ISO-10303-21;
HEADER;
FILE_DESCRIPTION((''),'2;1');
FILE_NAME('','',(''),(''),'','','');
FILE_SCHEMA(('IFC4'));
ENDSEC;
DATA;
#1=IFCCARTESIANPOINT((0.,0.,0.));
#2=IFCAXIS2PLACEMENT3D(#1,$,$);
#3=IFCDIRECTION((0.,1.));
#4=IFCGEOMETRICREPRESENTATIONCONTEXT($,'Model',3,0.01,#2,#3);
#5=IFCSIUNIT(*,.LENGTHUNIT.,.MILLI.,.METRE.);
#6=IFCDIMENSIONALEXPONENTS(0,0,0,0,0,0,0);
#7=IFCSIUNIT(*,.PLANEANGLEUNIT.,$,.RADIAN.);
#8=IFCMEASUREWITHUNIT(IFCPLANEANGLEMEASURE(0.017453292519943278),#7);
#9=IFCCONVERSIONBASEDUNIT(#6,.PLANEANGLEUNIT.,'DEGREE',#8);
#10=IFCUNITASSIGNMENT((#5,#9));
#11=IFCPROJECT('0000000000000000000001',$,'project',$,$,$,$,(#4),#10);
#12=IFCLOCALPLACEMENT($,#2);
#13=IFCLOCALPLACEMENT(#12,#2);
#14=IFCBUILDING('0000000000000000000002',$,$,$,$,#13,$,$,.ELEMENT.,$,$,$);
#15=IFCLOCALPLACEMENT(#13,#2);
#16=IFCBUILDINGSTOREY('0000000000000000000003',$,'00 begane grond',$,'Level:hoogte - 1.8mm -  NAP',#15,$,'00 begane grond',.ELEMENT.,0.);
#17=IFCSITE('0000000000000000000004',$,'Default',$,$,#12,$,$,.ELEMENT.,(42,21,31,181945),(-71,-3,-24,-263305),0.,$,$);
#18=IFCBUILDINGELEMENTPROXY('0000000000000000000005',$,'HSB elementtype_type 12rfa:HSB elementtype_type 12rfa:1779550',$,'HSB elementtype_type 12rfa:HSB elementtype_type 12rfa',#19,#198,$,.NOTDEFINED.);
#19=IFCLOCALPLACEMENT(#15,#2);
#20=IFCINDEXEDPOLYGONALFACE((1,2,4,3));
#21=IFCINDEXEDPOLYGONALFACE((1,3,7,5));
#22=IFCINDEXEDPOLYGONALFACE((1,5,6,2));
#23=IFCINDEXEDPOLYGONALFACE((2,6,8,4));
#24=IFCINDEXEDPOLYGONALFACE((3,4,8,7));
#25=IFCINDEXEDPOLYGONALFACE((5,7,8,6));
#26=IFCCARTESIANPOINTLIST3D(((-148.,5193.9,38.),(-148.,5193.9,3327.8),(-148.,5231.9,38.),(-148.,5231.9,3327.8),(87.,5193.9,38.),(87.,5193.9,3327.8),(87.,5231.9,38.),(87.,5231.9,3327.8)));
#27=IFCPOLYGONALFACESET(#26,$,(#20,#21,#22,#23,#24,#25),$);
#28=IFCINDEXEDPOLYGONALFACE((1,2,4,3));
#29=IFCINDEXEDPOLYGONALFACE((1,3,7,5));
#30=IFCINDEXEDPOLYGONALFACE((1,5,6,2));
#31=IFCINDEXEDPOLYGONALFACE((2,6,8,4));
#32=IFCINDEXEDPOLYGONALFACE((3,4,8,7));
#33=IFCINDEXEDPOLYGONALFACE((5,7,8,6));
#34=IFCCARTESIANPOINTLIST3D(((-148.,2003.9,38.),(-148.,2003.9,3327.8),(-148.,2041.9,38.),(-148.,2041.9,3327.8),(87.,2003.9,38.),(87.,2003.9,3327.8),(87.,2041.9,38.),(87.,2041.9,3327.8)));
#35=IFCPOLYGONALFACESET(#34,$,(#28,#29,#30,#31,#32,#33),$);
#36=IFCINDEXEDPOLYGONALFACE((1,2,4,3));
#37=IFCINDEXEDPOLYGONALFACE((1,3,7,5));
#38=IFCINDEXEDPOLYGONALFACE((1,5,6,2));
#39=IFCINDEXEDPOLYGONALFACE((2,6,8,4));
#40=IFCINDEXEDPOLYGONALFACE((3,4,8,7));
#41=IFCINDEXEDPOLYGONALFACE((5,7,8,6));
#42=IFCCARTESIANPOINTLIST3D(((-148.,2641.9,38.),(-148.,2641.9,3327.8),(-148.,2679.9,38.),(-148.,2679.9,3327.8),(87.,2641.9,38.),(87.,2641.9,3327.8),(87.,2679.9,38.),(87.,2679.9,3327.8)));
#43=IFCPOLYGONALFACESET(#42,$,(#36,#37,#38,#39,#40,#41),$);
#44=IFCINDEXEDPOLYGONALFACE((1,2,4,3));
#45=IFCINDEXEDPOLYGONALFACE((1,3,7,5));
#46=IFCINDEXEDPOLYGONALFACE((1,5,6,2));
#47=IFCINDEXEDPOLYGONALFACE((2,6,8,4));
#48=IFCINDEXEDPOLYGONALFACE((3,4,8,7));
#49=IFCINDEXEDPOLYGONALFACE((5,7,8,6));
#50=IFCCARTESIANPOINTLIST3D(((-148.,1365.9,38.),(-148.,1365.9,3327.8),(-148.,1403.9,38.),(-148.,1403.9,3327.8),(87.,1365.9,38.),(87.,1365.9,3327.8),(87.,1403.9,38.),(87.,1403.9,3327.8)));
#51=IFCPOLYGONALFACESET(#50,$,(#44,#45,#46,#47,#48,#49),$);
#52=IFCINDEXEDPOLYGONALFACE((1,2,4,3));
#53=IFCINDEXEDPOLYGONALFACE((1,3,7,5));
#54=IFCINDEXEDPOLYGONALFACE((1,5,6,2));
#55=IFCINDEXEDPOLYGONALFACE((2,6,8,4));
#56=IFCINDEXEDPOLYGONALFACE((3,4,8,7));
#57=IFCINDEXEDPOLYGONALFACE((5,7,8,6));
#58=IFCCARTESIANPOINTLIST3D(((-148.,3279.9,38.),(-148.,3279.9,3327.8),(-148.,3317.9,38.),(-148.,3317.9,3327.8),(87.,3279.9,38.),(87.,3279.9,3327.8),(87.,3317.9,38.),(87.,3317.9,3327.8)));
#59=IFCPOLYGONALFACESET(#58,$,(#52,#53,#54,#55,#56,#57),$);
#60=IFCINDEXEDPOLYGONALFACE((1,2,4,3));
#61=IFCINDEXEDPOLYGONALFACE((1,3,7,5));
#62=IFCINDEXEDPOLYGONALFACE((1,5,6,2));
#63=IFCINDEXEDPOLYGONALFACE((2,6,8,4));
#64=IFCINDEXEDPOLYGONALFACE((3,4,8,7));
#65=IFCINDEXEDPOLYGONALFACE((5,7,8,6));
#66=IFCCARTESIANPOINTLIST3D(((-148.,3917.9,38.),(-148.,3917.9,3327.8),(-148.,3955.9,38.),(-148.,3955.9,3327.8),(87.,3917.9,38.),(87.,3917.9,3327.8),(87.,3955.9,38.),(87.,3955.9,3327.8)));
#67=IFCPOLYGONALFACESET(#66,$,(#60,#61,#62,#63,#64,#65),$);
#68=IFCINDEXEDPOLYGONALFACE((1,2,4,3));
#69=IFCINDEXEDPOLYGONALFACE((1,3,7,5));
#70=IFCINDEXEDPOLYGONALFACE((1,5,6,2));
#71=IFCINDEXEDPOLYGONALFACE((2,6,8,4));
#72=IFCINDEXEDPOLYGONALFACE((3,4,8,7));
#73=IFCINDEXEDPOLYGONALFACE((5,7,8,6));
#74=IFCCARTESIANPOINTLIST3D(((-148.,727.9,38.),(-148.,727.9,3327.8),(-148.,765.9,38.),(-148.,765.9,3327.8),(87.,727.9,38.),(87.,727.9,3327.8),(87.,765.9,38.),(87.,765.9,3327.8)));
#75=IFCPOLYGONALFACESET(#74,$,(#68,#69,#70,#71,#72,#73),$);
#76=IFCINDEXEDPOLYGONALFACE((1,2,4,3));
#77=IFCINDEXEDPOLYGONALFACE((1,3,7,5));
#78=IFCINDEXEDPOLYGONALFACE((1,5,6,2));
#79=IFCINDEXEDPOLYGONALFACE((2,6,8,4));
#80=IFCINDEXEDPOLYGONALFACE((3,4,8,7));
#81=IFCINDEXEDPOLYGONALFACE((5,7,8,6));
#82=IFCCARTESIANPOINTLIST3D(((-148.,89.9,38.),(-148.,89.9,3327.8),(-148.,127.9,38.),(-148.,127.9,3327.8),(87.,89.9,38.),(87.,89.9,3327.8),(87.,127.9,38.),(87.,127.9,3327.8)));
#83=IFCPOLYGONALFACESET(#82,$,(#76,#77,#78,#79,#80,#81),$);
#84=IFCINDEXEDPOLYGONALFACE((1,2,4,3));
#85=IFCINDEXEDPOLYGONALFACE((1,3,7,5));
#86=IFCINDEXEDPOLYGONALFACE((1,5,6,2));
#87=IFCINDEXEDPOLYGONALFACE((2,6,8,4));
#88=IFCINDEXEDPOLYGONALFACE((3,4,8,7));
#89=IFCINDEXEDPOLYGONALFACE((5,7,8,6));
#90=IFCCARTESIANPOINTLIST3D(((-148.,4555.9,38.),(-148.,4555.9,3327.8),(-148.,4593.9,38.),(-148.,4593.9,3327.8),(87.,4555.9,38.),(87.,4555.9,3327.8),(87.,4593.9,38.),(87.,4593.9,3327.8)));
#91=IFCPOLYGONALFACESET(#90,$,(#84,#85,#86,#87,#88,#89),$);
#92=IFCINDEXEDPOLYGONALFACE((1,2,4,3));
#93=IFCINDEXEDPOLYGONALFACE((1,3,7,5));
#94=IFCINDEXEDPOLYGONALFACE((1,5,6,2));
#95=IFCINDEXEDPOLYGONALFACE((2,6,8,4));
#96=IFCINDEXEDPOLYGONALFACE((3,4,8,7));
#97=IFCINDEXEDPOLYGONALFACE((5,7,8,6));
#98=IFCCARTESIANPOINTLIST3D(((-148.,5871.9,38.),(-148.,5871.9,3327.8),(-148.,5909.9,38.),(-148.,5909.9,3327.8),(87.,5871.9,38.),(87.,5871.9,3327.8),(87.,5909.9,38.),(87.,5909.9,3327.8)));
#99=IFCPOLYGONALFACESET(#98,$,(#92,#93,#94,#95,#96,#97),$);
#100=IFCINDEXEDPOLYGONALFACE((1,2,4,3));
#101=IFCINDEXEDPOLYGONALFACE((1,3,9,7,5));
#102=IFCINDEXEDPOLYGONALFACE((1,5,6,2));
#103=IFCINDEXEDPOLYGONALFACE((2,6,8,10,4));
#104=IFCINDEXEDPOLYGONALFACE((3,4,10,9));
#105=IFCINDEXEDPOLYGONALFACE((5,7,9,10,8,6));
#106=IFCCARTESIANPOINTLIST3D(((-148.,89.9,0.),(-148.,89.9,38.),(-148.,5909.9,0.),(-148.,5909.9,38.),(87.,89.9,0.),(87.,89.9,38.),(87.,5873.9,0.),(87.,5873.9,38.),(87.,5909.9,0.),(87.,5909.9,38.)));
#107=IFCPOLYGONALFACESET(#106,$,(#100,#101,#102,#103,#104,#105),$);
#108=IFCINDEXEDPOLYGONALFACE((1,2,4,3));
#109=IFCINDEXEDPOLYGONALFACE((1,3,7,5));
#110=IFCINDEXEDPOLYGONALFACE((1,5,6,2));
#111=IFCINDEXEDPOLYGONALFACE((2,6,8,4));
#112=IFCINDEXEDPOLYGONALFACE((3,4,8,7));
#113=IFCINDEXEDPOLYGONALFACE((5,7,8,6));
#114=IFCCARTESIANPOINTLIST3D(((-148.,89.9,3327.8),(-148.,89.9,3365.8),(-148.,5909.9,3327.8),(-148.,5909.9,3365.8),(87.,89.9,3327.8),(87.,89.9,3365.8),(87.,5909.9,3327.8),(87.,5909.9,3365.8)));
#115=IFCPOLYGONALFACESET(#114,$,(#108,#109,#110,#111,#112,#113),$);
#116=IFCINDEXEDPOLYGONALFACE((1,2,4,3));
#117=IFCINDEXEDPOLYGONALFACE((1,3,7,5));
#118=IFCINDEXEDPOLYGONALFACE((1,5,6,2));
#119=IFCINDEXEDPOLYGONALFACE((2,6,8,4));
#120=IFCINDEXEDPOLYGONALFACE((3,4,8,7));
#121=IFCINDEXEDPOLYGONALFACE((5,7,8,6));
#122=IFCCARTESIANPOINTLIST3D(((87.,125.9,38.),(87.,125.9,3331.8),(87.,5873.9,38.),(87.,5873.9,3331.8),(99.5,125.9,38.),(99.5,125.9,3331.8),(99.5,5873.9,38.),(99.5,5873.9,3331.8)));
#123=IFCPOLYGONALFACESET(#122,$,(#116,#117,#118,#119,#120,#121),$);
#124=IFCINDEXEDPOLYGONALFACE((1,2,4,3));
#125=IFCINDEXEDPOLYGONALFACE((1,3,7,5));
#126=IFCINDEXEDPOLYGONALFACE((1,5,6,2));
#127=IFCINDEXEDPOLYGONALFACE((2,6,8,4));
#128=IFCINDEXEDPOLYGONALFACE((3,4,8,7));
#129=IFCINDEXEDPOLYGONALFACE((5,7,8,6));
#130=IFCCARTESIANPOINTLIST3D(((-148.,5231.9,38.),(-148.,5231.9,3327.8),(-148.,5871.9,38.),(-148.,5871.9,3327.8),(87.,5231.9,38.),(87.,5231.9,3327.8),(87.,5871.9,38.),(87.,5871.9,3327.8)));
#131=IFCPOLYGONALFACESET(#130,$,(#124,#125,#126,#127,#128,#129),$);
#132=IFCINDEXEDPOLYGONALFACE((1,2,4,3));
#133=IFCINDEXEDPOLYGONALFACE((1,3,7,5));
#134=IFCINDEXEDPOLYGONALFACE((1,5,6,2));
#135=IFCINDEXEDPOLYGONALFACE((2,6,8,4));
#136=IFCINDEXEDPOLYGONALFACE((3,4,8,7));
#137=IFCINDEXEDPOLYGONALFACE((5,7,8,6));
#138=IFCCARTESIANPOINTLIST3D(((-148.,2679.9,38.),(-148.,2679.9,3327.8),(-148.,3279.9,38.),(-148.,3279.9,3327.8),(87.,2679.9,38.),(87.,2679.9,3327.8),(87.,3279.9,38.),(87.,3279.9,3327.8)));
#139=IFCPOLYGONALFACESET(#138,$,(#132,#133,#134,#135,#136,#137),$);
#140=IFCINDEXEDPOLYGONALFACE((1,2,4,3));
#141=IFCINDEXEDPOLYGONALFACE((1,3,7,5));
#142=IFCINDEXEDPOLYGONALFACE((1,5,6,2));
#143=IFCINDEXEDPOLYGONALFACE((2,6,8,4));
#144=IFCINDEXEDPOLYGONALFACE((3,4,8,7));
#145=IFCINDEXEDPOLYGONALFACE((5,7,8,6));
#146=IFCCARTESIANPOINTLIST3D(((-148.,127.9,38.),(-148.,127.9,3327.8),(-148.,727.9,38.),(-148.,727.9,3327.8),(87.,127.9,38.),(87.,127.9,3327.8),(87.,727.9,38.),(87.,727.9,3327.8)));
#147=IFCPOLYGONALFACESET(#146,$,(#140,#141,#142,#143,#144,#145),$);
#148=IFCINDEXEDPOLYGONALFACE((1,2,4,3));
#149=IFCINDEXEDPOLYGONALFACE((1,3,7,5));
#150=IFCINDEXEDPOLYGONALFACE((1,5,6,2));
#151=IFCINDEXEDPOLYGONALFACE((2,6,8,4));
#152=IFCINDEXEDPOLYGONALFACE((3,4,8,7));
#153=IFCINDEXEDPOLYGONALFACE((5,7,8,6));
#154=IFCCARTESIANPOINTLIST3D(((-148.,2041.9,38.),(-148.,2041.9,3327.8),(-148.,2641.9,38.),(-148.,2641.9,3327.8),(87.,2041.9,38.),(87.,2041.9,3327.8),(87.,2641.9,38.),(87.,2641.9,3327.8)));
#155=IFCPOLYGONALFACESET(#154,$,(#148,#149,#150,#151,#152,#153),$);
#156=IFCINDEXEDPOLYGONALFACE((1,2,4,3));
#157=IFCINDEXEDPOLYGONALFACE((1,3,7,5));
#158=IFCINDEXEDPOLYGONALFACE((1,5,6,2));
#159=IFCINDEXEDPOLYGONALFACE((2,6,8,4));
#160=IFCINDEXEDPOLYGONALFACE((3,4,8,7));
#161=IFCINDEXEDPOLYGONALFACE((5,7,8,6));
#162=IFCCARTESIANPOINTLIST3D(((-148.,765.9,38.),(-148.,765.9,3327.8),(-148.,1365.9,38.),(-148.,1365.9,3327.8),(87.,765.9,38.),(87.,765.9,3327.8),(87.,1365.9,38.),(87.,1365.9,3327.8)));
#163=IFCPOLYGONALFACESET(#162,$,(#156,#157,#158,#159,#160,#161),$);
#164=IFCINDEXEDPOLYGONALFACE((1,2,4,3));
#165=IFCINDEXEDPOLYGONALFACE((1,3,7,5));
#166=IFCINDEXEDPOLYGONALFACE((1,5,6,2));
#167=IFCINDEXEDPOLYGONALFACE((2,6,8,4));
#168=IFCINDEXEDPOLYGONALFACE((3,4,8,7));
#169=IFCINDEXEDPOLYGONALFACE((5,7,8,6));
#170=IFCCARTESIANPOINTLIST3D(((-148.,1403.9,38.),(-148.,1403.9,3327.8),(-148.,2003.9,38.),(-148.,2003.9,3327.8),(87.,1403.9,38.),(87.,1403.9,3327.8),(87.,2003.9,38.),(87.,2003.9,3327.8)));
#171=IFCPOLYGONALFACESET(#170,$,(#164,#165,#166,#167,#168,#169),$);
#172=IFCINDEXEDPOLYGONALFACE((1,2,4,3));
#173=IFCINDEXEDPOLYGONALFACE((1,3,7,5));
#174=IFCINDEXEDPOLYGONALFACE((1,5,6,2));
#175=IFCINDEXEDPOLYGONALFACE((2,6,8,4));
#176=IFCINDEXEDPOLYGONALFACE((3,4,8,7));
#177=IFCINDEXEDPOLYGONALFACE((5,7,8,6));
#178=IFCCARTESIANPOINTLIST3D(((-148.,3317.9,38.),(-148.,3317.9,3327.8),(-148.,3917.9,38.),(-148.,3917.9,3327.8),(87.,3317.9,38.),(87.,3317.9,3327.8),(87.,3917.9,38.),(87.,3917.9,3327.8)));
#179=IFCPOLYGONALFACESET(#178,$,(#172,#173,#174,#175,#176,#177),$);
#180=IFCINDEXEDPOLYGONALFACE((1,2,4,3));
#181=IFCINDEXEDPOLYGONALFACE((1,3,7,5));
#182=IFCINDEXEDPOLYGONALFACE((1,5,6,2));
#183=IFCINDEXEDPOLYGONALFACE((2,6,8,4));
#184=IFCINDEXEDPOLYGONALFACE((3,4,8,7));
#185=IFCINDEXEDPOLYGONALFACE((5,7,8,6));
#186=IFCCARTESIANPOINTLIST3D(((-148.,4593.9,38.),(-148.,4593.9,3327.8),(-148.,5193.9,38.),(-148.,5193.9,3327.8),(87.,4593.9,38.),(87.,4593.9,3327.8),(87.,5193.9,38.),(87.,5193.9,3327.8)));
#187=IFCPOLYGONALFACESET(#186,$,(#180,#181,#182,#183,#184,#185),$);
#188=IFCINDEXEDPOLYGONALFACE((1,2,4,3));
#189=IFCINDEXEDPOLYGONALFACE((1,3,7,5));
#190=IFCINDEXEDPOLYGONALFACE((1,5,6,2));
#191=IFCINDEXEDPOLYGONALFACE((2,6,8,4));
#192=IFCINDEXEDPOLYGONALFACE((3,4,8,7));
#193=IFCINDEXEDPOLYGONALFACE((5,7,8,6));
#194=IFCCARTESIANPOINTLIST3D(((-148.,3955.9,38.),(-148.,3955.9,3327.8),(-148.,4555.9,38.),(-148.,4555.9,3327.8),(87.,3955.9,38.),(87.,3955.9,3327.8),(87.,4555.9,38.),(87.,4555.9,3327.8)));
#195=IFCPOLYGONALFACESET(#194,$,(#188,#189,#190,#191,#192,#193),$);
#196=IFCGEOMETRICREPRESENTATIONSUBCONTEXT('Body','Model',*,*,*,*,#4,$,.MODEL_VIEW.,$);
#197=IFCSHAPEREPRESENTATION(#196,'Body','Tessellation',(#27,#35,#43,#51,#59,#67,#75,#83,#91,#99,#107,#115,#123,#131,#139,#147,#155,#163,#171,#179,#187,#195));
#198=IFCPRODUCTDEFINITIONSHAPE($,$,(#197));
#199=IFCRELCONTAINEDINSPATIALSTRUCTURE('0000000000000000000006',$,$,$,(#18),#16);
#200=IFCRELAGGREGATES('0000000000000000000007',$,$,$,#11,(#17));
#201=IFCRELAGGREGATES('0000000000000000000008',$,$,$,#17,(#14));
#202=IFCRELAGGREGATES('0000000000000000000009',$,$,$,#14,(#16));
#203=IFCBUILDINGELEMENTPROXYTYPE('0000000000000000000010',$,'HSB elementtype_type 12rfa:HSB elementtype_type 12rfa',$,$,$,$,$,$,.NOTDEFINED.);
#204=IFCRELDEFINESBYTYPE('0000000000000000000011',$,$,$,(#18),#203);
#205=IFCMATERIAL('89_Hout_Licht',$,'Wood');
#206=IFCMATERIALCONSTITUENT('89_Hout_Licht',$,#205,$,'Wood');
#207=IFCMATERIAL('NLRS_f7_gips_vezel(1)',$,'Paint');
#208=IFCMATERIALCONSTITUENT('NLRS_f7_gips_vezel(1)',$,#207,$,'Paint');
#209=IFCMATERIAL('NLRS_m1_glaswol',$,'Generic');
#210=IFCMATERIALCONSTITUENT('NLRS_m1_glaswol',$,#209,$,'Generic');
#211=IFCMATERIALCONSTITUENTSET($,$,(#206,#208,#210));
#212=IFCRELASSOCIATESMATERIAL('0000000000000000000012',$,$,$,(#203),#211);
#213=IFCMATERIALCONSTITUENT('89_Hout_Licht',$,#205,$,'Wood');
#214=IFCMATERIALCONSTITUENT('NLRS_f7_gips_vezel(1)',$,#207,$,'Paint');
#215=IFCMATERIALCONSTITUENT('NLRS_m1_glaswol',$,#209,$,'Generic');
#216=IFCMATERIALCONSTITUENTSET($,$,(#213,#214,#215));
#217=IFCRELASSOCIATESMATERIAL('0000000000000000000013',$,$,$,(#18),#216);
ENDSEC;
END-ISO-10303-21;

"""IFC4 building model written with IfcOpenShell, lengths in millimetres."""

from ifc_helpers import new_model, entity, si_unit, converted_unit, direction, frame, origin, place, context, subcontext, project, spatial, indexed_curve, outline, extrude, source, transform, mapped, material, constituent, constituent_set, type_object, type_shapes, element, save


model = new_model("IFC4")

# Units and contexts
model_context = context("Model", 3, precision=0.01, world=origin(), true_north=direction((0.0, 1.0)))
body_context = subcontext(model_context, "Body", "Model", "MODEL_VIEW")
ifc_project = project(units=[si_unit("LENGTHUNIT", "METRE", prefix="MILLI"), converted_unit("PLANEANGLEUNIT", "DEGREE", entity("IfcPlaneAngleMeasure", 0.017453292519943278), si_unit("PLANEANGLEUNIT", "RADIAN"), dimensions=[0, 0, 0, 0, 0, 0, 0])], contexts=[model_context])

# Site, building, storey
site_placement = place(None, origin())
site = spatial("IfcSite", under=ifc_project, at=site_placement, Name="Default", CompositionType="ELEMENT", RefLatitude=(42, 21, 31, 181945), RefLongitude=(-71, -3, -24, -263305), RefElevation=0.0)
building_placement = place(site_placement, origin())
building = spatial("IfcBuilding", under=site, at=building_placement, CompositionType="ELEMENT")
storey_placement = place(building_placement, origin())
storey = spatial("IfcBuildingStorey", under=building, at=storey_placement, Name="00 begane grond", ObjectType="Level:hoogte - 1.8mm -  NAP", LongName="00 begane grond", CompositionType="ELEMENT", Elevation=0.0)

# Shared definitions
ifc_material_1 = material(Name="NLRS_f7_gips_vezel(1)", Category="Paint")

# Shared definitions
ifc_material_2 = material(Name="NLRS_m1_glaswol", Category="Generic")

# Building element proxy
ifc_material_3 = material(Name="89_Hout_Licht", Category="Wood")
ifc_constituent_1 = constituent(ifc_material_3, Name="89_Hout_Licht", Category="Wood")
ifc_constituent_2 = constituent(ifc_material_1, Name="NLRS_f7_gips_vezel(1)", Category="Paint")
ifc_constituent_3 = constituent(ifc_material_2, Name="NLRS_m1_glaswol", Category="Generic")
ifc_constituent_set_1 = constituent_set(constituents=[ifc_constituent_1, ifc_constituent_2, ifc_constituent_3])
ifc_constituent_4 = constituent(ifc_material_3, Name="89_Hout_Licht", Category="Wood")
ifc_constituent_5 = constituent(ifc_material_1, Name="NLRS_f7_gips_vezel(1)", Category="Paint")
ifc_constituent_6 = constituent(ifc_material_2, Name="NLRS_m1_glaswol", Category="Generic")
ifc_constituent_set_2 = constituent_set(constituents=[ifc_constituent_4, ifc_constituent_5, ifc_constituent_6])
building_element_proxy_type_1 = type_object("IfcBuildingElementProxyType", Name="HSB elementtype_type 12rfa:HSB elementtype_type 12rfa", PredefinedType="NOTDEFINED", material=ifc_constituent_set_2)
shared_shape_1 = source(origin(), body_context, "Body", "SweptSolid", [
    extrude(outline(indexed_curve([(-117.5, -19.0), (117.5, -19.0), (117.5, 19.0), (-117.5, 19.0), (-117.5, -19.0)], self_intersect=False)), frame((-30.5, 5212.9, 38.0)), (0.0, 0.0, 1.0), 3289.8),
    extrude(outline(indexed_curve([(-117.5, -19.0), (117.5, -19.0), (117.5, 19.0), (-117.5, 19.0), (-117.5, -19.0)], self_intersect=False)), frame((-30.5, 2022.9, 38.0)), (0.0, 0.0, 1.0), 3289.8),
    extrude(outline(indexed_curve([(-117.5, -19.0), (117.5, -19.0), (117.5, 19.0), (-117.5, 19.0), (-117.5, -19.0)], self_intersect=False)), frame((-30.5, 2660.9, 38.0)), (0.0, 0.0, 1.0), 3289.8),
    extrude(outline(indexed_curve([(-117.5, -19.0), (117.5, -19.0), (117.5, 19.0), (-117.5, 19.0), (-117.5, -19.0)], self_intersect=False)), frame((-30.5, 1384.9, 38.0)), (0.0, 0.0, 1.0), 3289.8),
    extrude(outline(indexed_curve([(-117.5, -19.0), (117.5, -19.0), (117.5, 19.0), (-117.5, 19.0), (-117.5, -19.0)], self_intersect=False)), frame((-30.5, 3298.9, 38.0)), (0.0, 0.0, 1.0), 3289.8),
    extrude(outline(indexed_curve([(-117.5, -19.0), (117.5, -19.0), (117.5, 19.0), (-117.5, 19.0), (-117.5, -19.0)], self_intersect=False)), frame((-30.5, 3936.9, 38.0)), (0.0, 0.0, 1.0), 3289.8),
    extrude(outline(indexed_curve([(-117.5, -19.0), (117.5, -19.0), (117.5, 19.0), (-117.5, 19.0), (-117.5, -19.0)], self_intersect=False)), frame((-30.5, 746.9, 38.0)), (0.0, 0.0, 1.0), 3289.8),
    extrude(outline(indexed_curve([(-117.5, -19.0), (117.5, -19.0), (117.5, 19.0), (-117.5, 19.0), (-117.5, -19.0)], self_intersect=False)), frame((-30.5, 108.9, 38.0)), (0.0, 0.0, 1.0), 3289.8),
    extrude(outline(indexed_curve([(-117.5, -19.0), (117.5, -19.0), (117.5, 19.0), (-117.5, 19.0), (-117.5, -19.0)], self_intersect=False)), frame((-30.5, 4574.9, 38.0)), (0.0, 0.0, 1.0), 3289.8),
    extrude(outline(indexed_curve([(-117.5, -19.0), (117.5, -19.0), (117.5, 19.0), (-117.5, 19.0), (-117.5, -19.0)], self_intersect=False)), frame((-30.5, 5890.9, 38.0)), (0.0, 0.0, 1.0), 3289.8),
    extrude(outline(indexed_curve([(-141.0, -3484.8), (94.0, -3484.8), (94.0, 2299.2), (94.0, 2335.2), (-141.0, 2335.2), (-141.0, -3484.8)], self_intersect=False)), frame((-7.0, 3574.7, 0.0)), (0.0, 0.0, 1.0), 38.0),
    extrude(outline(indexed_curve([(-117.5, -2910.0), (117.5, -2910.0), (117.5, 2910.0), (-117.5, 2910.0), (-117.5, -2910.0)], self_intersect=False)), frame((-30.5, 2999.9, 3327.8)), (0.0, 0.0, 1.0), 38.0),
    extrude(outline(indexed_curve([(-6.3, -2874.0), (6.2, -2874.0), (6.3, 2874.0), (-6.2, 2874.0), (-6.3, -2874.0)], self_intersect=False)), frame((93.2, 2999.9, 38.0)), (0.0, 0.0, 1.0), 3293.8),
    extrude(outline(indexed_curve([(-117.5, -320.0), (117.5, -320.0), (117.5, 320.0), (-117.5, 320.0), (-117.5, -320.0)], self_intersect=False)), frame((-30.5, 5551.9, 38.0)), (0.0, 0.0, 1.0), 3289.8),
    extrude(outline(indexed_curve([(-117.5, -300.0), (117.5, -300.0), (117.5, 300.0), (-117.5, 300.0), (-117.5, -300.0)], self_intersect=False)), frame((-30.5, 2979.9, 38.0)), (0.0, 0.0, 1.0), 3289.8),
    extrude(outline(indexed_curve([(-117.5, -300.0), (117.5, -300.0), (117.5, 300.0), (-117.5, 300.0), (-117.5, -300.0)], self_intersect=False)), frame((-30.5, 427.9, 38.0)), (0.0, 0.0, 1.0), 3289.8),
    extrude(outline(indexed_curve([(-117.5, -300.0), (117.5, -300.0), (117.5, 300.0), (-117.5, 300.0), (-117.5, -300.0)], self_intersect=False)), frame((-30.5, 2341.9, 38.0)), (0.0, 0.0, 1.0), 3289.8),
    extrude(outline(indexed_curve([(-117.5, -300.0), (117.5, -300.0), (117.5, 300.0), (-117.5, 300.0), (-117.5, -300.0)], self_intersect=False)), frame((-30.5, 1065.9, 38.0)), (0.0, 0.0, 1.0), 3289.8),
    extrude(outline(indexed_curve([(-117.5, -300.0), (117.5, -300.0), (117.5, 300.0), (-117.5, 300.0), (-117.5, -300.0)], self_intersect=False)), frame((-30.5, 1703.9, 38.0)), (0.0, 0.0, 1.0), 3289.8),
    extrude(outline(indexed_curve([(-117.5, -300.0), (117.5, -300.0), (117.5, 300.0), (-117.5, 300.0), (-117.5, -300.0)], self_intersect=False)), frame((-30.5, 3617.9, 38.0)), (0.0, 0.0, 1.0), 3289.8),
    extrude(outline(indexed_curve([(-117.5, -300.0), (117.5, -300.0), (117.5, 300.0), (-117.5, 300.0), (-117.5, -300.0)], self_intersect=False)), frame((-30.5, 4893.9, 38.0)), (0.0, 0.0, 1.0), 3289.8),
    extrude(outline(indexed_curve([(-117.5, -300.0), (117.5, -300.0), (117.5, 300.0), (-117.5, 300.0), (-117.5, -300.0)], self_intersect=False)), frame((-30.5, 4255.9, 38.0)), (0.0, 0.0, 1.0), 3289.8),
])
type_shapes(building_element_proxy_type_1, [shared_shape_1])
proxy_1_placement = place(storey_placement, origin())
element("IfcBuildingElementProxy", 1, at=proxy_1_placement, inside=storey, type_object=building_element_proxy_type_1, material=ifc_constituent_set_1, Name="HSB elementtype_type 12rfa:HSB elementtype_type 12rfa:1779550", ObjectType="HSB elementtype_type 12rfa:HSB elementtype_type 12rfa", PredefinedType="NOTDEFINED", context=body_context, shape_type="MappedRepresentation", body=[
    mapped(shared_shape_1, transform((0.0, 0.0, 0.0), scale=1.0)),
])

save(model, "model.ifc")
